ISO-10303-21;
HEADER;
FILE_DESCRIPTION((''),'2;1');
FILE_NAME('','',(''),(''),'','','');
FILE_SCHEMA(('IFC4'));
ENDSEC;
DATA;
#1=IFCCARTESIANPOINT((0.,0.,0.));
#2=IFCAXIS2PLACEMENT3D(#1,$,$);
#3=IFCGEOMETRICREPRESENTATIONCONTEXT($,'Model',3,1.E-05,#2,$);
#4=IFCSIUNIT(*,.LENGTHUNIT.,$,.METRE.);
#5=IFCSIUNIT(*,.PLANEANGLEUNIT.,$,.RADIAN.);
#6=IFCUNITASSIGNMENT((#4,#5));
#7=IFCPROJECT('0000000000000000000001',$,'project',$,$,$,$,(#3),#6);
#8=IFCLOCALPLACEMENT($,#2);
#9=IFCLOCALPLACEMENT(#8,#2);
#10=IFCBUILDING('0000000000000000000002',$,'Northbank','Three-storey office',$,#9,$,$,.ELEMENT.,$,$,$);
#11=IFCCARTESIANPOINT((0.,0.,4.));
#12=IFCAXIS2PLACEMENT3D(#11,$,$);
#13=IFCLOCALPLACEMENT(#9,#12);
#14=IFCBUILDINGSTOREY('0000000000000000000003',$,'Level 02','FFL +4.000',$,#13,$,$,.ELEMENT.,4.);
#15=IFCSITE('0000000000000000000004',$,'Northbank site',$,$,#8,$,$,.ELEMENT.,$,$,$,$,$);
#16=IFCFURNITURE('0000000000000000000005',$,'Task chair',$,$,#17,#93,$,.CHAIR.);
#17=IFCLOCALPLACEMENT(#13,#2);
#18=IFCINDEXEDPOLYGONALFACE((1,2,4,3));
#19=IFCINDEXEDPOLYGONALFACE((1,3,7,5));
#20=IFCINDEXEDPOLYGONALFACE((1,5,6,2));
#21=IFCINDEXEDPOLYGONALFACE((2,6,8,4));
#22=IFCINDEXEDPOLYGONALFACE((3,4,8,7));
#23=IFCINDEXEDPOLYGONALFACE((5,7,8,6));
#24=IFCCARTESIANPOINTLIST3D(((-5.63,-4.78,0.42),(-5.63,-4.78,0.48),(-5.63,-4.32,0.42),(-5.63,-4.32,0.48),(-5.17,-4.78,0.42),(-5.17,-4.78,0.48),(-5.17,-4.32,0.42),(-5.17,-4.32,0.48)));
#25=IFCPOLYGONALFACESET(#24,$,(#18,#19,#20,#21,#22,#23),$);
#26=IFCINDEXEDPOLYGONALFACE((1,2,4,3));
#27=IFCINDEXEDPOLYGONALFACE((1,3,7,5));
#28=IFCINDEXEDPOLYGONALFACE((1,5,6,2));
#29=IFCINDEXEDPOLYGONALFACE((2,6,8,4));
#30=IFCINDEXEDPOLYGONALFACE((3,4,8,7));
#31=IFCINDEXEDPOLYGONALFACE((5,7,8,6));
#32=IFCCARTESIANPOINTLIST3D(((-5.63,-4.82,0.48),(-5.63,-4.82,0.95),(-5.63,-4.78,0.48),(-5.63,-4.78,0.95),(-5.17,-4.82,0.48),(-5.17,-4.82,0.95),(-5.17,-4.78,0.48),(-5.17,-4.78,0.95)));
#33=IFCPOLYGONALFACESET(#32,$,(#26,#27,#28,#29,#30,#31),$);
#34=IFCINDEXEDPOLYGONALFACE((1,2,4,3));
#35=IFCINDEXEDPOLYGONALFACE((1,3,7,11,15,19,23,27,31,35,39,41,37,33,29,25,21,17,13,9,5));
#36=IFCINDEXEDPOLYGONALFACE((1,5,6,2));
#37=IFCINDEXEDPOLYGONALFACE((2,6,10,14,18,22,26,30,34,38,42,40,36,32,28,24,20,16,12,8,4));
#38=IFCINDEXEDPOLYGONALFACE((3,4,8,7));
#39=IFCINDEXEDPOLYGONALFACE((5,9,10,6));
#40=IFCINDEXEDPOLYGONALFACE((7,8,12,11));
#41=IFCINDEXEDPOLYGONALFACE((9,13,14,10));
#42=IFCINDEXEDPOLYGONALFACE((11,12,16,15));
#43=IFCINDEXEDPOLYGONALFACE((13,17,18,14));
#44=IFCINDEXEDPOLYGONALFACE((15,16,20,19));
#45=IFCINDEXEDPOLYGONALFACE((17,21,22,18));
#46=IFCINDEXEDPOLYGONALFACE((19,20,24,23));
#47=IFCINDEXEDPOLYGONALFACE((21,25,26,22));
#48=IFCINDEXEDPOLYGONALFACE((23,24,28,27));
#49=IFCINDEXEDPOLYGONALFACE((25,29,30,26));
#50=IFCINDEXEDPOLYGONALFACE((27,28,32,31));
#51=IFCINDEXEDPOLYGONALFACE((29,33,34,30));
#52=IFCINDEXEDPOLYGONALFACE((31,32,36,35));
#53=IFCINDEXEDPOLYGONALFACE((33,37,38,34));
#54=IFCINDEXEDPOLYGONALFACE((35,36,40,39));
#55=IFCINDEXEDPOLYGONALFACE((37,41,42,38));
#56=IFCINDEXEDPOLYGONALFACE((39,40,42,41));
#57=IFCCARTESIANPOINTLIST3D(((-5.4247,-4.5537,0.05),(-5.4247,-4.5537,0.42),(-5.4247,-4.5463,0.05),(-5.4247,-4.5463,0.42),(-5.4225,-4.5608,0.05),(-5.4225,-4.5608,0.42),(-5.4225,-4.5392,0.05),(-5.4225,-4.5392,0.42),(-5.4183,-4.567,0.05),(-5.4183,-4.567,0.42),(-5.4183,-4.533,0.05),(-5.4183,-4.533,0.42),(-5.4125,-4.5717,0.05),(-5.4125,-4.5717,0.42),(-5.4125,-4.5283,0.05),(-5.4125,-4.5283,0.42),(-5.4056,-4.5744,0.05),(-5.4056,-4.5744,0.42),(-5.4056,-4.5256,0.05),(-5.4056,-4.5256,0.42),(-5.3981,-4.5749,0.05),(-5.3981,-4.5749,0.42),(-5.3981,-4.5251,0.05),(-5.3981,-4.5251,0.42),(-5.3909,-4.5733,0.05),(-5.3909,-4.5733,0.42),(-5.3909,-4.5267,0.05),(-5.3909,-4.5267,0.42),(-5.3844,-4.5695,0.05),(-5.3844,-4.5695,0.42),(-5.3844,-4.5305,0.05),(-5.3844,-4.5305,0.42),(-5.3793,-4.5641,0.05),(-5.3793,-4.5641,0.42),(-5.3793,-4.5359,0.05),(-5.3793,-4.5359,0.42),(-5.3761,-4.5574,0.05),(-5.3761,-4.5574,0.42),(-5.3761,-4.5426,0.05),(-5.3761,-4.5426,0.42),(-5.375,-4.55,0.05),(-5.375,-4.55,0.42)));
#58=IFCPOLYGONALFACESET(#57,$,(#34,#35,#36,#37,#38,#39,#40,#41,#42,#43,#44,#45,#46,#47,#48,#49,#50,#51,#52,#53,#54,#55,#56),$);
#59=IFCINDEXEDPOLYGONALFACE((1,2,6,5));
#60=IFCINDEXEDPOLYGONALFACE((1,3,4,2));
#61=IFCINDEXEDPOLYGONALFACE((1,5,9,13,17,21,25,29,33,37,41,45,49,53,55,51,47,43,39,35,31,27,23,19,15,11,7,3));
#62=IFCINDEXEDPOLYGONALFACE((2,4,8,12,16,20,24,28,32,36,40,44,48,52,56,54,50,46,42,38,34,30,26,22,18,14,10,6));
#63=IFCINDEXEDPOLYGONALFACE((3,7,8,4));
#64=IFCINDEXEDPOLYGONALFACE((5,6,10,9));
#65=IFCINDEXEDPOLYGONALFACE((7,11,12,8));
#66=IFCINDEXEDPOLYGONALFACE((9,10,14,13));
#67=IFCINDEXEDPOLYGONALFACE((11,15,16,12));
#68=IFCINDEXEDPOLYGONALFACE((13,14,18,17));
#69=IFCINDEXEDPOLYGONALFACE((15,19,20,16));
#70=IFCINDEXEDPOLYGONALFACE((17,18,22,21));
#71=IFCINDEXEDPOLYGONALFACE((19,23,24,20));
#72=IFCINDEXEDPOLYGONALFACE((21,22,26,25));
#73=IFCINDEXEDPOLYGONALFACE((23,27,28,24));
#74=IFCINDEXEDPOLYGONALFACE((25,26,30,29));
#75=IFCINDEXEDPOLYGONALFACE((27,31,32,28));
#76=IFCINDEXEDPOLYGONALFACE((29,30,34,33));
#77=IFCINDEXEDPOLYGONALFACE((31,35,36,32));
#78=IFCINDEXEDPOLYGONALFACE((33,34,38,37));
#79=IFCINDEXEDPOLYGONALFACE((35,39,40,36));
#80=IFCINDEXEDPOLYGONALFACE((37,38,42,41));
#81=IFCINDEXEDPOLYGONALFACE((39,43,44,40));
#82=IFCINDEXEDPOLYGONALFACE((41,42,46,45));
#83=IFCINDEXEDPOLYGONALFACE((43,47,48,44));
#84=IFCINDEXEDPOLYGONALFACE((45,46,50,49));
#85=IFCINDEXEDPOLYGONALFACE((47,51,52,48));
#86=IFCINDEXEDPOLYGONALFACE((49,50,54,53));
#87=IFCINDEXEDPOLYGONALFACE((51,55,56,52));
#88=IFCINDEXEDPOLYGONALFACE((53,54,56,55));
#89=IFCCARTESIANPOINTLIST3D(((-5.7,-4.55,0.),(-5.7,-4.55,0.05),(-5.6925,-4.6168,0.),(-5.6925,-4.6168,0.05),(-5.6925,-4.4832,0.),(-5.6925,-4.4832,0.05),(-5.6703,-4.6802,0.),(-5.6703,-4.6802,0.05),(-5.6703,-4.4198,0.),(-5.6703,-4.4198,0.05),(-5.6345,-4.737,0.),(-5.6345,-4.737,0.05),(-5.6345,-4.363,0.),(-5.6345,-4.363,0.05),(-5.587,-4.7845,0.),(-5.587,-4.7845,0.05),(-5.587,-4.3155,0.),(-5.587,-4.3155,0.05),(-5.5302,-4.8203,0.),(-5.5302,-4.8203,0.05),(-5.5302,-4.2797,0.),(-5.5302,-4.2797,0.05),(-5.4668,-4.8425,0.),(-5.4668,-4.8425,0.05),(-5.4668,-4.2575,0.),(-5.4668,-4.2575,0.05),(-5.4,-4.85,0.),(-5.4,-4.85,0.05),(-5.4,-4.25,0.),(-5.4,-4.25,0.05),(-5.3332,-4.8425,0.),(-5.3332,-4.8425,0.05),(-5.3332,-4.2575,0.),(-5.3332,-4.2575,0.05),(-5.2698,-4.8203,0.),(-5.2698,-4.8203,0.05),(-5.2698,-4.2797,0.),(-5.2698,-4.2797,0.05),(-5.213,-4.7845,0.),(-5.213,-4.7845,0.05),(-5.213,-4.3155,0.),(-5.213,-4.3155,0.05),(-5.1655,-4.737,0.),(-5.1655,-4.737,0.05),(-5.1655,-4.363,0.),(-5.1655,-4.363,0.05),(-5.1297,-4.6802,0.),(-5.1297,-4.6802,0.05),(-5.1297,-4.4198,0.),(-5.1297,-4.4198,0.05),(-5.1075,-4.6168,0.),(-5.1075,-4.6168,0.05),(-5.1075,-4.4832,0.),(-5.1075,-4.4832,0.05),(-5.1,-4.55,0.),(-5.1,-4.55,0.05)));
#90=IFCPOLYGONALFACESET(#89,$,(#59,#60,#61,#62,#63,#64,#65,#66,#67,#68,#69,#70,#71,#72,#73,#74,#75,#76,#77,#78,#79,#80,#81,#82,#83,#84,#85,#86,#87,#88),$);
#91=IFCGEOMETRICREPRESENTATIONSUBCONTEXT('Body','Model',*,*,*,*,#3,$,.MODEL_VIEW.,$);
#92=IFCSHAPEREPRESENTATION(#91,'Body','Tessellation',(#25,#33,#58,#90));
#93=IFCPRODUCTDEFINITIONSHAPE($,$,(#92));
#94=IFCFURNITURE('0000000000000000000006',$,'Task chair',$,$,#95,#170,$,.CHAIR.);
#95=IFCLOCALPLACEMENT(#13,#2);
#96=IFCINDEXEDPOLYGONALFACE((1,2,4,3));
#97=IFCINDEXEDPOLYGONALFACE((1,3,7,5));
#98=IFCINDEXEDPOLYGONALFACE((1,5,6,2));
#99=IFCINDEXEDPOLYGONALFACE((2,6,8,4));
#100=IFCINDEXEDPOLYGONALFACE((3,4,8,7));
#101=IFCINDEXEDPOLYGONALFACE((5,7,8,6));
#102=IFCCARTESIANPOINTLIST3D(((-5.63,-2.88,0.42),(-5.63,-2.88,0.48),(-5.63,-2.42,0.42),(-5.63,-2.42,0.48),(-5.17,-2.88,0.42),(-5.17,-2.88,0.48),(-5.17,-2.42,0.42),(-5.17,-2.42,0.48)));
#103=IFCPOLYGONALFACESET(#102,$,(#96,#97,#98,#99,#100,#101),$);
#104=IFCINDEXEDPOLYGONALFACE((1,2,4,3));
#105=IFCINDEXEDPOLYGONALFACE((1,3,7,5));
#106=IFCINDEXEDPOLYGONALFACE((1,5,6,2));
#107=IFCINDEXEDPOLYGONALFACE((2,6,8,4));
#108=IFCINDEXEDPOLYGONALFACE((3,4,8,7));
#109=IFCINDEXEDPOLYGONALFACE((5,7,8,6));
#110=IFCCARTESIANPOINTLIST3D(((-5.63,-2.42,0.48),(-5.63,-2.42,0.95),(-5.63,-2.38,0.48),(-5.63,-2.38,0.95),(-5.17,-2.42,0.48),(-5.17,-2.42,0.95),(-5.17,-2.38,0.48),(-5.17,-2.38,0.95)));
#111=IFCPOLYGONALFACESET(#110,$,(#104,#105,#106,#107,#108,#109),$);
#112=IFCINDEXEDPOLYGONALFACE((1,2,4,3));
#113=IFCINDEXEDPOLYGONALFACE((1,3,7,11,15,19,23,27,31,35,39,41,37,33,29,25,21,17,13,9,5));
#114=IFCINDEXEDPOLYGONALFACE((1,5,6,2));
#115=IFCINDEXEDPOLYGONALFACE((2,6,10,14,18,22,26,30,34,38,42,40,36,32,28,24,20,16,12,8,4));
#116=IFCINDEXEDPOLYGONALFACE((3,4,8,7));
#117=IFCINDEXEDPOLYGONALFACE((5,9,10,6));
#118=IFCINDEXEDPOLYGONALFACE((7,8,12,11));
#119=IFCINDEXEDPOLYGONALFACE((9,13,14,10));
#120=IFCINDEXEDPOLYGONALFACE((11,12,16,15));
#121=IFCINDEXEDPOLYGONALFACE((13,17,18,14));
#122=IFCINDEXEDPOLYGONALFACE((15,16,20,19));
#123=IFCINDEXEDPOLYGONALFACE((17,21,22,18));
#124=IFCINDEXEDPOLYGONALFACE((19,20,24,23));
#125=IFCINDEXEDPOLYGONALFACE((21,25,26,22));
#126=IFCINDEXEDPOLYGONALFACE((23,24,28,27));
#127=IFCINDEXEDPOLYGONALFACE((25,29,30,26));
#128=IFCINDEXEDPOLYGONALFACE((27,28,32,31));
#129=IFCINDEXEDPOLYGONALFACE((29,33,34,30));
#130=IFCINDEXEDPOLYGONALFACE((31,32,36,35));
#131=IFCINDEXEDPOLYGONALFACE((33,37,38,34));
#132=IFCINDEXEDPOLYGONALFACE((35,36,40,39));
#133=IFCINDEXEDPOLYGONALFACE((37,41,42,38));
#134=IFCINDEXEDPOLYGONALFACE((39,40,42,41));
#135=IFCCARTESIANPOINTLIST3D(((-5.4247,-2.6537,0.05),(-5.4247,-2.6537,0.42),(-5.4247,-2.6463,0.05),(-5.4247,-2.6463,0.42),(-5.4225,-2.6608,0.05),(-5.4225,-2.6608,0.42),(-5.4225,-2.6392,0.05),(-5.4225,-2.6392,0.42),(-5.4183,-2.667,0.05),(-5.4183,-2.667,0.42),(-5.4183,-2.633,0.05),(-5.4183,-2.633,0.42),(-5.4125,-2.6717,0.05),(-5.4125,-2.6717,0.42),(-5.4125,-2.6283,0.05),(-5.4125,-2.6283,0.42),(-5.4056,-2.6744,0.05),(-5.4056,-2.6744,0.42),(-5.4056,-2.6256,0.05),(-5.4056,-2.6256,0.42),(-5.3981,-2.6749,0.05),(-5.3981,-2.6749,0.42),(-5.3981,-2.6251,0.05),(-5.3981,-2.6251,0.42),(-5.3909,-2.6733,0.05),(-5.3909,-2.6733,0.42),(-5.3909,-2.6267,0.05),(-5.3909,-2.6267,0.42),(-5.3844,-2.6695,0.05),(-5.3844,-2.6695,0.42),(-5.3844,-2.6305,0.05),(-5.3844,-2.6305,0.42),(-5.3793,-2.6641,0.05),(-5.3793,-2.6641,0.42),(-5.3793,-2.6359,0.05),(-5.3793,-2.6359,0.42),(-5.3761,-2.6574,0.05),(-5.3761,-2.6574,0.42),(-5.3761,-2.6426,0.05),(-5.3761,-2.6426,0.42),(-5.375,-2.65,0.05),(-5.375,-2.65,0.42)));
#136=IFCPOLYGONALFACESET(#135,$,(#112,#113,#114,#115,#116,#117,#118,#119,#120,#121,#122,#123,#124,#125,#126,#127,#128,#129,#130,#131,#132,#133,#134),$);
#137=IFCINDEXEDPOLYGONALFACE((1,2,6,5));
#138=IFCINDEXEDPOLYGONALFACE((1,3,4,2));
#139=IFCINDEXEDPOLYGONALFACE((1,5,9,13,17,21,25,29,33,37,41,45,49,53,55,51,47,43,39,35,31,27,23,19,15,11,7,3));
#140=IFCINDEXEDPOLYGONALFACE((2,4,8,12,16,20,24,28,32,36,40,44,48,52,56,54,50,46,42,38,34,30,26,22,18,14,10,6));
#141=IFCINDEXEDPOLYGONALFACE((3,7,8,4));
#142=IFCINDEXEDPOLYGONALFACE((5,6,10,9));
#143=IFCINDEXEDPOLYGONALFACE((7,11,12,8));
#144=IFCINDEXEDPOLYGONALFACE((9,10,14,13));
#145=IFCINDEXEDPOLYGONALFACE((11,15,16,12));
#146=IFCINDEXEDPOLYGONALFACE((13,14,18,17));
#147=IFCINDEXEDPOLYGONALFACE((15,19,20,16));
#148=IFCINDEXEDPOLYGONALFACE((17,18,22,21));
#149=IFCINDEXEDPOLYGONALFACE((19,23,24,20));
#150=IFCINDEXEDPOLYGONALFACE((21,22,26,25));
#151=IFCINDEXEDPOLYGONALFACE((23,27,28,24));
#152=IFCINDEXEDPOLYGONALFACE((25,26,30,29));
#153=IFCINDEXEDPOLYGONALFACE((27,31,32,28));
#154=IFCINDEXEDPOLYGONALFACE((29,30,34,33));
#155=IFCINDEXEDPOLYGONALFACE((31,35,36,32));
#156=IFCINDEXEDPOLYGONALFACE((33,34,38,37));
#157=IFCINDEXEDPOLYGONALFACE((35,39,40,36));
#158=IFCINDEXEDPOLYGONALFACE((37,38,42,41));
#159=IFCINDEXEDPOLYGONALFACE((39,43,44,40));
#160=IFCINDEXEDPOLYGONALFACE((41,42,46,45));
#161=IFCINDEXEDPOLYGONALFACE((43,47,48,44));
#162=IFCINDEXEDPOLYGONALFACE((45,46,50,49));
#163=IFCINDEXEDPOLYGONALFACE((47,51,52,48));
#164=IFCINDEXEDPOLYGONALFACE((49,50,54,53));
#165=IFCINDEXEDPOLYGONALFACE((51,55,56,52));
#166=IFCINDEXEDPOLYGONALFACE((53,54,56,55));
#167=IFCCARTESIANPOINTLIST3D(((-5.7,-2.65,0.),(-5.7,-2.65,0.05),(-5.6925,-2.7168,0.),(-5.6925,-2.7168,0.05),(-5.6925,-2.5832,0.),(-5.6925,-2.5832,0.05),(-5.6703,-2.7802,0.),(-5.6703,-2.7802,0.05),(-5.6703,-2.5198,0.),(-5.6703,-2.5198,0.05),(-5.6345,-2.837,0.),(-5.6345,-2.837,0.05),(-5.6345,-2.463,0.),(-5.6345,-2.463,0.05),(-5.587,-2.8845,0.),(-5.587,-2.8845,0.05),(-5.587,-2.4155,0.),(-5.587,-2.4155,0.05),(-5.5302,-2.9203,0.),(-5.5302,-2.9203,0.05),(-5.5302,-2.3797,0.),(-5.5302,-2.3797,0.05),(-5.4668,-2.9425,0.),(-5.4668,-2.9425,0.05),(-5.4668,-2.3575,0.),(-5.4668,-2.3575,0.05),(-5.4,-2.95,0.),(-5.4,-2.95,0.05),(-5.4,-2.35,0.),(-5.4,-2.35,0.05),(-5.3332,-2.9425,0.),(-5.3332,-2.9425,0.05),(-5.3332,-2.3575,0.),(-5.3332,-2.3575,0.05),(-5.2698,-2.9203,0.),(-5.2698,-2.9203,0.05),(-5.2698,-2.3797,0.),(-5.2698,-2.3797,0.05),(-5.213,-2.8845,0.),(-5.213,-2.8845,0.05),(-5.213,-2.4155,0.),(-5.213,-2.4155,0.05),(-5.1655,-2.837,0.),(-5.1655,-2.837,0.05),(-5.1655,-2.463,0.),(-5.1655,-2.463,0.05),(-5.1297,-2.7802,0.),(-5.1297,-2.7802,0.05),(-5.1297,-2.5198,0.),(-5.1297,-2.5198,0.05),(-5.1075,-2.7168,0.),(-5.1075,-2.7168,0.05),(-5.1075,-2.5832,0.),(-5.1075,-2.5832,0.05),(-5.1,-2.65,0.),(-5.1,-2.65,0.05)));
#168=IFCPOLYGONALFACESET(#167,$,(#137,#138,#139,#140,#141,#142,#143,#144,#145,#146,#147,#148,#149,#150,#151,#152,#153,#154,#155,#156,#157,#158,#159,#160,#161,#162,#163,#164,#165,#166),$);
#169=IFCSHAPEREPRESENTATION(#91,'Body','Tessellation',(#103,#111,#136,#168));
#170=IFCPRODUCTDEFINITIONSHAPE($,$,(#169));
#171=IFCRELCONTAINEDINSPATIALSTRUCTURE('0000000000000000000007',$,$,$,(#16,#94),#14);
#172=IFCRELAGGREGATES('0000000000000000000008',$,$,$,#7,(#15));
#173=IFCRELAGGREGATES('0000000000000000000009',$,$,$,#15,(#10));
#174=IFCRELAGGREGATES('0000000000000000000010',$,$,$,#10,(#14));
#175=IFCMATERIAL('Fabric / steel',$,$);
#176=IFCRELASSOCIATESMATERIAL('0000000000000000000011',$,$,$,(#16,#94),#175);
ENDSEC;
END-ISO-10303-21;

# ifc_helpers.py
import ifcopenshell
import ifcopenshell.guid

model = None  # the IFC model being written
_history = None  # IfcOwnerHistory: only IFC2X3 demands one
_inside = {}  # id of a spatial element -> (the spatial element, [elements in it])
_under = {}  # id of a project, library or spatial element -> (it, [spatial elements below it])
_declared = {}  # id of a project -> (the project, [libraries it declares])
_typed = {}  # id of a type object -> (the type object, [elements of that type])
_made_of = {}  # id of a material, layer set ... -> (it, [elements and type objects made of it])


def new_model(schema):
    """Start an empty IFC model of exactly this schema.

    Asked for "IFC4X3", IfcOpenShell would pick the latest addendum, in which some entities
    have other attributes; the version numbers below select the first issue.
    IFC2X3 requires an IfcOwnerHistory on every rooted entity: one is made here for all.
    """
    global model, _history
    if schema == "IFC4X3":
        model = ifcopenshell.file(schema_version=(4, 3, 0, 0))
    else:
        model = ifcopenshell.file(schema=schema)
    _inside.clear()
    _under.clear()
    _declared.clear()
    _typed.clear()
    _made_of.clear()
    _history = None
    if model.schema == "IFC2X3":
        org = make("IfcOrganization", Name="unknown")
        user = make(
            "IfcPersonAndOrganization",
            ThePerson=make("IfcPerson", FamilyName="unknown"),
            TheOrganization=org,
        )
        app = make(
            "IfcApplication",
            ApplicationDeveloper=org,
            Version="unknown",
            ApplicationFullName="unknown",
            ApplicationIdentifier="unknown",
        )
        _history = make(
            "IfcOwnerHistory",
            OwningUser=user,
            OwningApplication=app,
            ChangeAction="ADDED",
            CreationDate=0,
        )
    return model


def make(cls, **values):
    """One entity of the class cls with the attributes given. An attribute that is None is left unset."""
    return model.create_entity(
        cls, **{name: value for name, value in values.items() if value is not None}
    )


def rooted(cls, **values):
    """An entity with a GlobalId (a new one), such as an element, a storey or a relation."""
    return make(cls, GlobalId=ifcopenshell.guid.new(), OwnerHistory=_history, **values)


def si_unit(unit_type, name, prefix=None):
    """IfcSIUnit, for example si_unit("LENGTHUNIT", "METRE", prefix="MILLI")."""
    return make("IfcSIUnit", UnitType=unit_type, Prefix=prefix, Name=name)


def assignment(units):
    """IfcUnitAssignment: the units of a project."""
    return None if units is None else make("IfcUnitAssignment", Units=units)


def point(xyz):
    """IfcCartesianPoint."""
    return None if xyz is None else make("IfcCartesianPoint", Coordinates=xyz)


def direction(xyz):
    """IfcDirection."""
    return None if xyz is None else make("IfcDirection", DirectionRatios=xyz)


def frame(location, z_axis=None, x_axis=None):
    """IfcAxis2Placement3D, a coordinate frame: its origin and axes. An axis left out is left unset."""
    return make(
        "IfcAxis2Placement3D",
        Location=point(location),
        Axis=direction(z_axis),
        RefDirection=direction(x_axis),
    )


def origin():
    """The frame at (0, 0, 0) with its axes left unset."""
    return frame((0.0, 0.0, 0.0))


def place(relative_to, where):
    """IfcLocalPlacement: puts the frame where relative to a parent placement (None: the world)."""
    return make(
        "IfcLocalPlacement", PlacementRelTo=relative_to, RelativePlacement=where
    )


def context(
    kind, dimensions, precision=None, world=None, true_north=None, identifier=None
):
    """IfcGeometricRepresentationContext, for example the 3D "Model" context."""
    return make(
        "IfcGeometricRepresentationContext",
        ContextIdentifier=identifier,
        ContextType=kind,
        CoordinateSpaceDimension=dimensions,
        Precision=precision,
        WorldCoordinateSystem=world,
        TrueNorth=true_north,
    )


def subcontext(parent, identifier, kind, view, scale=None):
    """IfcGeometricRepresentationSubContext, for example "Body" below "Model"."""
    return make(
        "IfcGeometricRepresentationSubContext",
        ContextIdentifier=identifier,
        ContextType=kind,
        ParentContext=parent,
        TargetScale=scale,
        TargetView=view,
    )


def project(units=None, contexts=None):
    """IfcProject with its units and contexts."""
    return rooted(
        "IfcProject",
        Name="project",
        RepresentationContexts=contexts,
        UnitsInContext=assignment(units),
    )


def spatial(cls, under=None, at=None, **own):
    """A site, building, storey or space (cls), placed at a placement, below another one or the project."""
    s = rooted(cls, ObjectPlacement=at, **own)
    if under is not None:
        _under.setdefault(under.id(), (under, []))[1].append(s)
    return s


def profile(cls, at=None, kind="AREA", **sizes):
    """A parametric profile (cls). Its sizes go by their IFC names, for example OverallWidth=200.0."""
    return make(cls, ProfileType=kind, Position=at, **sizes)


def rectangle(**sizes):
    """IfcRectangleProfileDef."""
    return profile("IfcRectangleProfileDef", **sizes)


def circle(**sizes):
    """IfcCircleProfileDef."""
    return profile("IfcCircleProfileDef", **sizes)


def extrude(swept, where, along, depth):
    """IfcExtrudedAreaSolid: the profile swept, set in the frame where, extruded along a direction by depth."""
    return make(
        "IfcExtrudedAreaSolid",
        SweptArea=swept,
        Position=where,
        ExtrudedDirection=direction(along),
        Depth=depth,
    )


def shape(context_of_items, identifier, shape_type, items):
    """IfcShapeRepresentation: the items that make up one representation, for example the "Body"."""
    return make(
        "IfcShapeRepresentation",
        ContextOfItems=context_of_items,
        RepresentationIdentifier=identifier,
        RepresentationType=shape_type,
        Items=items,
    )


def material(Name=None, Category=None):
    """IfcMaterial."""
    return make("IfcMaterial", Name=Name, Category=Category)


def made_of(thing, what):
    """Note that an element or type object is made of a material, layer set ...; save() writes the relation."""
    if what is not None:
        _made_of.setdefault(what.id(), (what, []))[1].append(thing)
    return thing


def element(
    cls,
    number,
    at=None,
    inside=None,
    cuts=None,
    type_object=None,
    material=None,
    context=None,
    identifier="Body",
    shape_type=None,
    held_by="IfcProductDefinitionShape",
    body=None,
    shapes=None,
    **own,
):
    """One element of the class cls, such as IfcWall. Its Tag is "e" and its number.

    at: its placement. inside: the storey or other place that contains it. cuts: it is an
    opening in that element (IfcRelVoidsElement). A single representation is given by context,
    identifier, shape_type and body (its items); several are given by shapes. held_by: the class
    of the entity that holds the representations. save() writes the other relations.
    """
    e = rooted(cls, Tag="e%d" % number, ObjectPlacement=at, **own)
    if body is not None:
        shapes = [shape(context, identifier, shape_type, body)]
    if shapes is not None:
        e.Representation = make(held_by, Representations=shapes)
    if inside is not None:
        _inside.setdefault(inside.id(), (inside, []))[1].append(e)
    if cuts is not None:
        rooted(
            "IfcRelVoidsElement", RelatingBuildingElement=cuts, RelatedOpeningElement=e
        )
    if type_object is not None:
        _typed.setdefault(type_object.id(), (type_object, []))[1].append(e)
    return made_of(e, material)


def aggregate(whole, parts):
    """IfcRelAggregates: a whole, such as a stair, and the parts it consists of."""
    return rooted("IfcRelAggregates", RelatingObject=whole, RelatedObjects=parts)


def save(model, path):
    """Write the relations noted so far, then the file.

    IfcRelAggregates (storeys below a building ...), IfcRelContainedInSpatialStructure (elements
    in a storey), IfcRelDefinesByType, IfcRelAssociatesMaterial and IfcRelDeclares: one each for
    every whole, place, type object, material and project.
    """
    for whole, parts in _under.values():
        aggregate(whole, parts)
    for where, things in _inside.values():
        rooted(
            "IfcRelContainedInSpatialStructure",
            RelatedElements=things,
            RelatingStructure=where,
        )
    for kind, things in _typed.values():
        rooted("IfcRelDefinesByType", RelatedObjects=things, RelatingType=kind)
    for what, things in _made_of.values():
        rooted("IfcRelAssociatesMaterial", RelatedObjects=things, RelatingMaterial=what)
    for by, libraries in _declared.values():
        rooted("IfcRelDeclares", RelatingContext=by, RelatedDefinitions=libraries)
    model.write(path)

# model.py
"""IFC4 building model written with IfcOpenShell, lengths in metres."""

from ifc_helpers import new_model, si_unit, frame, origin, place, context, subcontext, project, spatial, rectangle, circle, extrude, material, element, save


model = new_model("IFC4")

# Units and contexts
model_context = context("Model", 3, precision=1e-05, world=origin())
body_context = subcontext(model_context, "Body", "Model", "MODEL_VIEW")
ifc_project = project(units=[si_unit("LENGTHUNIT", "METRE"), si_unit("PLANEANGLEUNIT", "RADIAN")], contexts=[model_context])

# Site, building, storey
site_placement = place(None, origin())
site = spatial("IfcSite", under=ifc_project, at=site_placement, Name="Northbank site", CompositionType="ELEMENT")
building_placement = place(site_placement, origin())
building = spatial("IfcBuilding", under=site, at=building_placement, Name="Northbank", Description="Three-storey office", CompositionType="ELEMENT")
storey_placement = place(building_placement, frame((0.0, 0.0, 4.0)))
storey = spatial("IfcBuildingStorey", under=building, at=storey_placement, Name="Level 02", Description="FFL +4.000", CompositionType="ELEMENT", Elevation=4.0)

# Furniture
ifc_material_1 = material(Name="Fabric / steel")
furniture_1_placement = place(storey_placement, frame((0.0, 0.0, -4.0)))
element("IfcFurniture", 1, at=furniture_1_placement, inside=storey, material=ifc_material_1, Name="Task chair", PredefinedType="CHAIR", context=body_context, shape_type="SweptSolid", body=[
    extrude(rectangle(XDim=0.46, YDim=0.46), frame((-5.4, -4.55, 4.42)), (0.0, 0.0, 1.0), 0.06),
    extrude(rectangle(XDim=0.46, YDim=0.04), frame((-5.4, -4.8, 4.48)), (0.0, 0.0, 1.0), 0.47),
    extrude(circle(Radius=0.025), frame((-5.4, -4.55, 4.05), z_axis=(0.0, 0.0, 1.0), x_axis=(1.0, 0.0, 0.0)), (0.0, 0.0, 1.0), 0.37),
    extrude(circle(Radius=0.3), frame((-5.4, -4.55, 4.0), z_axis=(0.0, 0.0, 1.0), x_axis=(1.0, 0.0, 0.0)), (0.0, 0.0, 1.0), 0.05),
])
furniture_2_placement = place(storey_placement, frame((0.0, 0.0, -4.0)))
element("IfcFurniture", 2, at=furniture_2_placement, inside=storey, material=ifc_material_1, Name="Task chair", PredefinedType="CHAIR", context=body_context, shape_type="SweptSolid", body=[
    extrude(rectangle(XDim=0.46, YDim=0.46), frame((-5.4, -2.65, 4.42)), (0.0, 0.0, 1.0), 0.06),
    extrude(rectangle(XDim=0.46, YDim=0.04), frame((-5.4, -2.4, 4.48)), (0.0, 0.0, 1.0), 0.47),
    extrude(circle(Radius=0.025), frame((-5.4, -2.65, 4.05), z_axis=(0.0, 0.0, 1.0), x_axis=(1.0, 0.0, 0.0)), (0.0, 0.0, 1.0), 0.37),
    extrude(circle(Radius=0.3), frame((-5.4, -2.65, 4.0), z_axis=(0.0, 0.0, 1.0), x_axis=(1.0, 0.0, 0.0)), (0.0, 0.0, 1.0), 0.05),
])

save(model, "model.ifc")
